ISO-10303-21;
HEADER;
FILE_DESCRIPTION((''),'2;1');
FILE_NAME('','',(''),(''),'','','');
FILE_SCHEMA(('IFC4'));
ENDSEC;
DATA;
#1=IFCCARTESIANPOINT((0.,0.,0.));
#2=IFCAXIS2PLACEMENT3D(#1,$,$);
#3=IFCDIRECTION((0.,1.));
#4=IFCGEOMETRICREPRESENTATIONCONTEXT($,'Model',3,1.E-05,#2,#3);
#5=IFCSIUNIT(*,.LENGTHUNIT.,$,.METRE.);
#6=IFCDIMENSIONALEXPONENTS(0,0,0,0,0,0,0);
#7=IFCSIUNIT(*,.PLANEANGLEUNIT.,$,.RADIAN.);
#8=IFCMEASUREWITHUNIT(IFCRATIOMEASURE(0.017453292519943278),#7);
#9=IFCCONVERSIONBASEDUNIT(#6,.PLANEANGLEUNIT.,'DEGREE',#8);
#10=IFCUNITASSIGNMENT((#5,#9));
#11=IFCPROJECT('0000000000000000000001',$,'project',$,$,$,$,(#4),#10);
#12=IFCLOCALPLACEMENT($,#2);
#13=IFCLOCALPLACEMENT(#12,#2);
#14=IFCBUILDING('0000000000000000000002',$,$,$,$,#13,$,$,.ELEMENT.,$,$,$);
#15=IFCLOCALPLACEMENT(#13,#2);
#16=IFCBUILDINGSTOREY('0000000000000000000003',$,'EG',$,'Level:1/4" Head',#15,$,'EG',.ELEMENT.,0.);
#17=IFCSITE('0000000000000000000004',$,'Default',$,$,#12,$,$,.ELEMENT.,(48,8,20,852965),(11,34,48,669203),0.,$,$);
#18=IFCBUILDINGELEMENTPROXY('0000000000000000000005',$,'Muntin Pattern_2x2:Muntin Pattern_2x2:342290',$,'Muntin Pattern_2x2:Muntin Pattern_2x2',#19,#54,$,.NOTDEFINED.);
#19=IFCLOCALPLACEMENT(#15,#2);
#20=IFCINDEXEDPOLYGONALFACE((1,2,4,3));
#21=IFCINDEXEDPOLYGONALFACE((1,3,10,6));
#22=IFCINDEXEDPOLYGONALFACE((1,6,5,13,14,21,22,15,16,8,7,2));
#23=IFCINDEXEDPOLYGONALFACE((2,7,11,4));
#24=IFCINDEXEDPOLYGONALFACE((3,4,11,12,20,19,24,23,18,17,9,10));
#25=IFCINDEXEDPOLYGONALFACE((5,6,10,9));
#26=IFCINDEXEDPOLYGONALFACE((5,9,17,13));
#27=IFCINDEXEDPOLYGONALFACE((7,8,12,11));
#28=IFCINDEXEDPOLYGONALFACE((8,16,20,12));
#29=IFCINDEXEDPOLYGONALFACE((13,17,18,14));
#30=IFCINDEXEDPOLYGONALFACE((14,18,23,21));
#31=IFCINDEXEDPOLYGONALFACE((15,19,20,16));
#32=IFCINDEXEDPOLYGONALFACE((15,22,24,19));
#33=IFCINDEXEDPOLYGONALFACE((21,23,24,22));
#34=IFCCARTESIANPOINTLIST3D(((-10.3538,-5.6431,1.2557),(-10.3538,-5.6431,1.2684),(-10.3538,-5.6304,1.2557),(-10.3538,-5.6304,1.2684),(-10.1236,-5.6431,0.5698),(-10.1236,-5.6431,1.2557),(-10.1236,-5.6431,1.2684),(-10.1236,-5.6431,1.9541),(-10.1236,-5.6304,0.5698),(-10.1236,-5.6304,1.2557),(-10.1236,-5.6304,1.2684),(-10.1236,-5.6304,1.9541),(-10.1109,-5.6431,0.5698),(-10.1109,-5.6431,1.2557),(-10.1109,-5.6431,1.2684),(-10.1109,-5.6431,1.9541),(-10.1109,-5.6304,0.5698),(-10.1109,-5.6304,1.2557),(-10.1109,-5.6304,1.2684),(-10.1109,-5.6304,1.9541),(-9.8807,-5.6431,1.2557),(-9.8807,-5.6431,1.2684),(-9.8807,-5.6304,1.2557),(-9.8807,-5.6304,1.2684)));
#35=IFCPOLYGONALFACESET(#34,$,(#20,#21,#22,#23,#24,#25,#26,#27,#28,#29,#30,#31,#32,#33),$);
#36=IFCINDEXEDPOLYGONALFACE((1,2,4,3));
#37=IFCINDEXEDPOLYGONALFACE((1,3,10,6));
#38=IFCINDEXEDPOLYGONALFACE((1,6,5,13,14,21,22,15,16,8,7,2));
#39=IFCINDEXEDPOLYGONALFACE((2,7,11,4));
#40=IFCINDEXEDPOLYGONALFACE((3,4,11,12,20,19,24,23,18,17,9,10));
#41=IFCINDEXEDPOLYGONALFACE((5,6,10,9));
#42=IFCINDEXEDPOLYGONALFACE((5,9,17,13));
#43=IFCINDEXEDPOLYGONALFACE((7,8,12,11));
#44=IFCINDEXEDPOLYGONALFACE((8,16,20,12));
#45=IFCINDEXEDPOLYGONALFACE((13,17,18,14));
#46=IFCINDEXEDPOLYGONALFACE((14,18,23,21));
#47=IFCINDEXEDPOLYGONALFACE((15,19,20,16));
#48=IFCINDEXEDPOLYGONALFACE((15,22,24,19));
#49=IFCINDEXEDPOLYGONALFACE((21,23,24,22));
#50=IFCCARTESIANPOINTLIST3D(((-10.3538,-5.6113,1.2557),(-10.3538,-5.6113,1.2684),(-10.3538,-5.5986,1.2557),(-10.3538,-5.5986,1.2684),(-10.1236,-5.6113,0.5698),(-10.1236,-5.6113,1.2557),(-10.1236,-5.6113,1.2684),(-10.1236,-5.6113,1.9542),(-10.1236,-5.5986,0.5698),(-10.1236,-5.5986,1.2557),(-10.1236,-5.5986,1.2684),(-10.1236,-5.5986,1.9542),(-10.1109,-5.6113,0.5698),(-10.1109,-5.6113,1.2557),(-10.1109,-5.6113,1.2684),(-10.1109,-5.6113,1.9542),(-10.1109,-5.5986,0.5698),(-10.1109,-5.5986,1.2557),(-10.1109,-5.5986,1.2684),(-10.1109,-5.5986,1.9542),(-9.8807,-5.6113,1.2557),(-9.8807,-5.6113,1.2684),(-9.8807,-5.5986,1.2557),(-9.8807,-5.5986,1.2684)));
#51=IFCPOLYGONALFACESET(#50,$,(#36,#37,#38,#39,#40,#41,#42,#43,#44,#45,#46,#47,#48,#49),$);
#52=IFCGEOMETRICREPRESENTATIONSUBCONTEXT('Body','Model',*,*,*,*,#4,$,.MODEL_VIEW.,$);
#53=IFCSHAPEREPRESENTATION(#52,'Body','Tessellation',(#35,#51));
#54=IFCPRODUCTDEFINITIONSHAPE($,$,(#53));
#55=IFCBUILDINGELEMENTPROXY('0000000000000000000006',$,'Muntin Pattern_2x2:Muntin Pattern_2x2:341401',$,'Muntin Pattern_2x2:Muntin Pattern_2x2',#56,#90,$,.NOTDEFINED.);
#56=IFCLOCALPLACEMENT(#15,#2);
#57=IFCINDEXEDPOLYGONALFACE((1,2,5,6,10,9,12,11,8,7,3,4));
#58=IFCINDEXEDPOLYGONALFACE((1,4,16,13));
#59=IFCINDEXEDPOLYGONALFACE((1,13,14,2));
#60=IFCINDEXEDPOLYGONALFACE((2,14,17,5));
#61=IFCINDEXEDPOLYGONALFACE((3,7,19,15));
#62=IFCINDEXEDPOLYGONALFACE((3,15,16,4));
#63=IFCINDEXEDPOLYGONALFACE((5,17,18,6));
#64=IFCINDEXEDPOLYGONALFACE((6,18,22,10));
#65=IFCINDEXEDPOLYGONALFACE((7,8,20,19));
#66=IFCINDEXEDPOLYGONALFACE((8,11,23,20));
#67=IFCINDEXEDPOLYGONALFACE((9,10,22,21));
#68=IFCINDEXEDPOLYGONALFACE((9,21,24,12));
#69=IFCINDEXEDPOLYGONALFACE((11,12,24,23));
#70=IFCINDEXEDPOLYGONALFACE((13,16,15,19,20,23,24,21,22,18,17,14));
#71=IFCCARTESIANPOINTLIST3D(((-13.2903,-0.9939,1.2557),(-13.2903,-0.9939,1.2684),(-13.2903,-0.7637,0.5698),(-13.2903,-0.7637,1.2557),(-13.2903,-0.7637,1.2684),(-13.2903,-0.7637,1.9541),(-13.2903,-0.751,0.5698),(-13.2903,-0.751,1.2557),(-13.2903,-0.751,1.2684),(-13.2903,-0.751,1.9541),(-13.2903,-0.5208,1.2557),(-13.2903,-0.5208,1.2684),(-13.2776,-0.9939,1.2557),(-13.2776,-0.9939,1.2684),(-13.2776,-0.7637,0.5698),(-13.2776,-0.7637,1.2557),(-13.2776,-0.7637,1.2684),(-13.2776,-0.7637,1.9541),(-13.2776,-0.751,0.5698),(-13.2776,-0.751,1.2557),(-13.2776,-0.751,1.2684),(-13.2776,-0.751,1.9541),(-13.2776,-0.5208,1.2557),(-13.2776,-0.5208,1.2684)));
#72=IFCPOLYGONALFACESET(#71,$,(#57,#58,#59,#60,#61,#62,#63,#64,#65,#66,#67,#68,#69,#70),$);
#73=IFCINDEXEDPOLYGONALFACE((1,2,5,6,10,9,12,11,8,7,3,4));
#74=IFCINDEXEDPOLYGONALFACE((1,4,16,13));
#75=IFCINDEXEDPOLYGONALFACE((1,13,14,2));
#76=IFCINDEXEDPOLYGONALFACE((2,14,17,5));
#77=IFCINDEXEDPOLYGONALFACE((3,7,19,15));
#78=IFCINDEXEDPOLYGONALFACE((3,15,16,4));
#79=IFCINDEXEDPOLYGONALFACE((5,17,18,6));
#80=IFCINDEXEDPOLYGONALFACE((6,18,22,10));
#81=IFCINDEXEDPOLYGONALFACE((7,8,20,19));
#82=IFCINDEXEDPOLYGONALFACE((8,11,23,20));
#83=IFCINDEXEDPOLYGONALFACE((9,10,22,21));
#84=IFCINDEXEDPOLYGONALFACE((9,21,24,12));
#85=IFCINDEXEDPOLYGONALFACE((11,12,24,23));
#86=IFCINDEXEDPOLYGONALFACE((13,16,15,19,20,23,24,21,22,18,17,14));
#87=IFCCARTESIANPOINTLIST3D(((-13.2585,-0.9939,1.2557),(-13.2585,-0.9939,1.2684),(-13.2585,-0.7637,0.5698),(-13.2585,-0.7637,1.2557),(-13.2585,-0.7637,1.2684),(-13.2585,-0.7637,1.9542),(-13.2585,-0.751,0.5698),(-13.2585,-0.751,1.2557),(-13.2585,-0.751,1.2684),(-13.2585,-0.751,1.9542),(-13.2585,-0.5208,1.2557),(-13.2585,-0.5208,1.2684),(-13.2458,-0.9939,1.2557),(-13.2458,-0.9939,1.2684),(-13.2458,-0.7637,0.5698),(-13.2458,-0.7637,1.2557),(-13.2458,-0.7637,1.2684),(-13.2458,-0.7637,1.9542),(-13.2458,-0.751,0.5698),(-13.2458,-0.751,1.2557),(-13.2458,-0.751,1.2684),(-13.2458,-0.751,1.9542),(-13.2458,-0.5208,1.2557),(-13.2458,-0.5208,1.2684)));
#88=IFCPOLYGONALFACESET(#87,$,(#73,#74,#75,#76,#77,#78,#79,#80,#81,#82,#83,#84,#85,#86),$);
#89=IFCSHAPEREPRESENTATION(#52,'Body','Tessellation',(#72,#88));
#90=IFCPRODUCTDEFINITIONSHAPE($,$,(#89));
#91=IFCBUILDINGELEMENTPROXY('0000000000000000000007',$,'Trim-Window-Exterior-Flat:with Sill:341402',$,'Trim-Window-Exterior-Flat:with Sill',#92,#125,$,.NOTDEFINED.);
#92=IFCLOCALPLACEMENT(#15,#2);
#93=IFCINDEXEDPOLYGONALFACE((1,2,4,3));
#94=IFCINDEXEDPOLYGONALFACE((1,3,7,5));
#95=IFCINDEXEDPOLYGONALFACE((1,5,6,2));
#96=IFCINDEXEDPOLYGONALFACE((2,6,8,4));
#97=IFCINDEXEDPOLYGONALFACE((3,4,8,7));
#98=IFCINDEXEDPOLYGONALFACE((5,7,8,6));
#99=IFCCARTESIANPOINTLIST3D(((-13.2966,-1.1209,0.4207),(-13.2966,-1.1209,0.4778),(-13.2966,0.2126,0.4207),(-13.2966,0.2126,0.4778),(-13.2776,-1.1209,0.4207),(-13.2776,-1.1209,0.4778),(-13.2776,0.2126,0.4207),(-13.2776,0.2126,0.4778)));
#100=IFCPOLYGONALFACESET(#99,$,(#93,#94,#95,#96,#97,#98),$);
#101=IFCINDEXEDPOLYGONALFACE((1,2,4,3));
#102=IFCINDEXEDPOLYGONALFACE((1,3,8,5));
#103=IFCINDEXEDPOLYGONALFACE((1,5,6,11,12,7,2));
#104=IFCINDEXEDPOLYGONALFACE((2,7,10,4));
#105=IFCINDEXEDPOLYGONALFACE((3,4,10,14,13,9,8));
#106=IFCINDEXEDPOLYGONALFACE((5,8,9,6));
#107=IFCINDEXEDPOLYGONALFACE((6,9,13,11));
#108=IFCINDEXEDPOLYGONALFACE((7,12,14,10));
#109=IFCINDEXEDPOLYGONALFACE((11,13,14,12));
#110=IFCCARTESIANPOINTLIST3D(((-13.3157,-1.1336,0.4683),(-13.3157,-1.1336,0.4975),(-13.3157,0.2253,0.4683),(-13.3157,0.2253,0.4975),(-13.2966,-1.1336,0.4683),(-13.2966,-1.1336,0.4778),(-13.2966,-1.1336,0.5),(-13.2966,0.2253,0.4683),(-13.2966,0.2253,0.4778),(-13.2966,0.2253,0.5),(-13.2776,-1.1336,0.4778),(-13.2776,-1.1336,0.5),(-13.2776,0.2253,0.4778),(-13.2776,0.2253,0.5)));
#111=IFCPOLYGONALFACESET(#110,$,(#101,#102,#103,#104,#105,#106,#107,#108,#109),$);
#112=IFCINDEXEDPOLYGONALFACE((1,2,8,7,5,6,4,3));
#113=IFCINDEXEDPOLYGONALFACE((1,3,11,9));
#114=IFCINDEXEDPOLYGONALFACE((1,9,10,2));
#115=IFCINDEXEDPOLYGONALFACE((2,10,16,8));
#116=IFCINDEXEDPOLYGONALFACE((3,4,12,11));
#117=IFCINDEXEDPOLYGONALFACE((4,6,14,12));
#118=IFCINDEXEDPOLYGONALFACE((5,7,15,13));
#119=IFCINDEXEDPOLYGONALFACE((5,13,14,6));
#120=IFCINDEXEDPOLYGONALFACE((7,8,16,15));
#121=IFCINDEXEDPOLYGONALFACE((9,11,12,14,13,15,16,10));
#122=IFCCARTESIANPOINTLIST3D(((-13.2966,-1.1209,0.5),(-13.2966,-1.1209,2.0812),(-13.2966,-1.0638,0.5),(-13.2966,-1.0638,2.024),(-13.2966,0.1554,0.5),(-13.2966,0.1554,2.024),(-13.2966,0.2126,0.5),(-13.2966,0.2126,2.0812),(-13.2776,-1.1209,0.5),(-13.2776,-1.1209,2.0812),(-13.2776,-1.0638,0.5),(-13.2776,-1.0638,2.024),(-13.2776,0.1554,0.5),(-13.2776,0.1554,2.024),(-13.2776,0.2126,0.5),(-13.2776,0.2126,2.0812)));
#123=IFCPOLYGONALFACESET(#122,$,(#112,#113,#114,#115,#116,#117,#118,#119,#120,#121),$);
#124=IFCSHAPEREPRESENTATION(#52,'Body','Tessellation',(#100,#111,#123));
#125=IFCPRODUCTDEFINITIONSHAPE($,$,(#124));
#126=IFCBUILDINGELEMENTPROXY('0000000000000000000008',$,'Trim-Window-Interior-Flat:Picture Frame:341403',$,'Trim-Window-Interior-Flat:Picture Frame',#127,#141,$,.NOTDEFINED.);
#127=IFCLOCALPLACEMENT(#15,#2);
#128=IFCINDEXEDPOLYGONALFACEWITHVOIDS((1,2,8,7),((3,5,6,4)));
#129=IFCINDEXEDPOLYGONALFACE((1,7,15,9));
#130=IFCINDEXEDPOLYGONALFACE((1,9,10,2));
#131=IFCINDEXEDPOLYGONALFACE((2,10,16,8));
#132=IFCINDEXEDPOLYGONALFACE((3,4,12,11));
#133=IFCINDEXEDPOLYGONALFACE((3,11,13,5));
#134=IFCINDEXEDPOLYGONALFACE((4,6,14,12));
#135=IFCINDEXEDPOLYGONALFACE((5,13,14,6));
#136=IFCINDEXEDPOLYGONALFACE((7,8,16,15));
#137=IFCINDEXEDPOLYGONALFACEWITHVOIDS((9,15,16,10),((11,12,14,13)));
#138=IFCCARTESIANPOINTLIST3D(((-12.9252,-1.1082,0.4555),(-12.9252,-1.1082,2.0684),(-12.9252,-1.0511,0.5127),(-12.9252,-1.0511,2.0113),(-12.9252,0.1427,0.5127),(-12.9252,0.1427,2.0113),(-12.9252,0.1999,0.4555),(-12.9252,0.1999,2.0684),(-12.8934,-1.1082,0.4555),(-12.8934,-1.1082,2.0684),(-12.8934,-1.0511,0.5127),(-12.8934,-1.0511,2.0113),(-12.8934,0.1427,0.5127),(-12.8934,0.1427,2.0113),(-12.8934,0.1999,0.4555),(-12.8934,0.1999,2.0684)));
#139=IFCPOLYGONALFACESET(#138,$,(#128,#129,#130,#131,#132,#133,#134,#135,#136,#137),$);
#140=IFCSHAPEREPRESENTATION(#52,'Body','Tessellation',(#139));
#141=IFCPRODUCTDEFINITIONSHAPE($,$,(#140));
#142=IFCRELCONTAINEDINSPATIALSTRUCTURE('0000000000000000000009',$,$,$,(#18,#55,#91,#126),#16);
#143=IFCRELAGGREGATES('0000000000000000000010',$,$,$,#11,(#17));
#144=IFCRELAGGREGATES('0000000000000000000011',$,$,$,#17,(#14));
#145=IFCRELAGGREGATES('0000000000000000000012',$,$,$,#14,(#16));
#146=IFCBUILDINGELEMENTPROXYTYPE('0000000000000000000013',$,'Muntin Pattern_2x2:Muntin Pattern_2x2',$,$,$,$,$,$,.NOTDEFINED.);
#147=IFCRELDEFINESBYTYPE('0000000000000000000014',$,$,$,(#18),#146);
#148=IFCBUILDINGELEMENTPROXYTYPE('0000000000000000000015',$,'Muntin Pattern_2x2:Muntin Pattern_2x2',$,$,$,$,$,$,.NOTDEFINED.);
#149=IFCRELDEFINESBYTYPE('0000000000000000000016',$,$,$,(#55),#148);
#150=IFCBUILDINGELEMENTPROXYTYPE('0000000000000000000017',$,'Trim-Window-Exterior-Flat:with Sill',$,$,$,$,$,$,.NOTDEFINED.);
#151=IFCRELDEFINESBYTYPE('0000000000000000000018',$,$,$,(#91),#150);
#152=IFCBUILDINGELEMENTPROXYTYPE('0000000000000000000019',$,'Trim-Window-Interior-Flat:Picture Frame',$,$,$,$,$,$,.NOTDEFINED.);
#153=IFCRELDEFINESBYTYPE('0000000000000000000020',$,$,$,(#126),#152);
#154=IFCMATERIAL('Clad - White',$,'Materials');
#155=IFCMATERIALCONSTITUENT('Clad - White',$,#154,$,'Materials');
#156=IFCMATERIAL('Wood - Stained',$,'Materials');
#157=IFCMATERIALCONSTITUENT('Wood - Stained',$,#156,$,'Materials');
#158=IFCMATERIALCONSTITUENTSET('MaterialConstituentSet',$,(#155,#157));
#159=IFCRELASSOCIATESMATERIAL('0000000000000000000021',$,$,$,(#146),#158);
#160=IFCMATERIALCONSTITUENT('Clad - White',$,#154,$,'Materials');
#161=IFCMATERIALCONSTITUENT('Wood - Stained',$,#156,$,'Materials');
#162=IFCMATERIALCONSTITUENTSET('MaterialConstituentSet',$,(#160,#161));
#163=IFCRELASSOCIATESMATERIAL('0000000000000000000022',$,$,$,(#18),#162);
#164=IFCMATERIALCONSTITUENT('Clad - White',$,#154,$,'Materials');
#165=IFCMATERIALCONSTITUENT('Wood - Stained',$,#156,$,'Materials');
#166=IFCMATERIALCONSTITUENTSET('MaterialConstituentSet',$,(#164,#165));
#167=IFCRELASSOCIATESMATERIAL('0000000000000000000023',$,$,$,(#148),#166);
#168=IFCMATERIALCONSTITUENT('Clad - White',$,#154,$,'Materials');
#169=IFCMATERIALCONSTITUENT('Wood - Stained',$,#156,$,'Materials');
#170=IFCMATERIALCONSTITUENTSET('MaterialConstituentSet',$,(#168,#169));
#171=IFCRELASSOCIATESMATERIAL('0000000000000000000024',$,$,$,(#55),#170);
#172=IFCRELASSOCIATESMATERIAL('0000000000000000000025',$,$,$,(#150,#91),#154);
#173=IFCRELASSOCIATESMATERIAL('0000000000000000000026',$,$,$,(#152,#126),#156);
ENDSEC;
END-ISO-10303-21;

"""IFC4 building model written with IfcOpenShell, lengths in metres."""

from ifc_helpers import new_model, entity, si_unit, converted_unit, direction, frame, origin, place, context, subcontext, project, spatial, indexed_curve, outline, extrude, source, transform, mapped, material, constituent, constituent_set, type_object, type_shapes, element, save


model = new_model("IFC4")

# Units and contexts
model_context = context("Model", 3, precision=1e-05, world=origin(), true_north=direction((0.0, 1.0)))
body_context = subcontext(model_context, "Body", "Model", "MODEL_VIEW")
ifc_project = project(units=[si_unit("LENGTHUNIT", "METRE"), converted_unit("PLANEANGLEUNIT", "DEGREE", entity("IfcRatioMeasure", 0.017453292519943278), si_unit("PLANEANGLEUNIT", "RADIAN"), dimensions=[0, 0, 0, 0, 0, 0, 0])], contexts=[model_context])

# Site, building, storey
site_placement = place(None, origin())
site = spatial("IfcSite", under=ifc_project, at=site_placement, Name="Default", CompositionType="ELEMENT", RefLatitude=(48, 8, 20, 852965), RefLongitude=(11, 34, 48, 669203), RefElevation=0.0)
building_placement = place(site_placement, origin())
building = spatial("IfcBuilding", under=site, at=building_placement, CompositionType="ELEMENT")
storey_placement = place(building_placement, origin())
storey = spatial("IfcBuildingStorey", under=building, at=storey_placement, Name="EG", ObjectType="Level:1/4\" Head", LongName="EG", CompositionType="ELEMENT", Elevation=0.0)

# Building element proxies
ifc_material_1 = material(Name="Clad - White", Category="Materials")
ifc_material_2 = material(Name="Wood - Stained", Category="Materials")
ifc_constituent_1 = constituent(ifc_material_1, Name="Clad - White", Category="Materials")
ifc_constituent_2 = constituent(ifc_material_2, Name="Wood - Stained", Category="Materials")
ifc_constituent_set_1 = constituent_set(constituents=[ifc_constituent_1, ifc_constituent_2], Name="MaterialConstituentSet")
building_element_proxy_type_1 = type_object("IfcBuildingElementProxyType", Name="Muntin Pattern_2x2:Muntin Pattern_2x2", PredefinedType="NOTDEFINED", material=ifc_constituent_set_1)
shared_shape_1 = source(origin(), body_context, "Body", "SweptSolid", [
    extrude(outline(indexed_curve([(0.0064, -0.0064), (0.6921, -0.0064), (0.6921, 0.0063), (0.0064, 0.0063), (0.0064, 0.2365), (-0.0063, 0.2365), (-0.0063, 0.0063), (-0.6922, 0.0063), (-0.6922, -0.0064), (-0.0063, -0.0064), (-0.0063, -0.2365), (0.0064, -0.2365), (0.0064, -0.0064)], self_intersect=False)), frame((0.0, -0.0222, 0.6921), z_axis=(0.0, 1.0, 0.0), x_axis=(0.0, 0.0, 1.0)), (0.0, 0.0, 1.0), 0.0127),
    extrude(outline(indexed_curve([(0.0064, -0.0064), (0.6922, -0.0064), (0.6922, 0.0063), (0.0064, 0.0063), (0.0064, 0.2365), (-0.0063, 0.2365), (-0.0063, 0.0063), (-0.6922, 0.0063), (-0.6922, -0.0064), (-0.0063, -0.0064), (-0.0063, -0.2365), (0.0064, -0.2365), (0.0064, -0.0064)], self_intersect=False)), frame((0.0, 0.0095, 0.6922), z_axis=(0.0, 1.0, 0.0), x_axis=(0.0, 0.0, 1.0)), (0.0, 0.0, 1.0), 0.0127),
])
type_shapes(building_element_proxy_type_1, [shared_shape_1])
ifc_constituent_3 = constituent(ifc_material_1, Name="Clad - White", Category="Materials")
ifc_constituent_4 = constituent(ifc_material_2, Name="Wood - Stained", Category="Materials")
ifc_constituent_set_2 = constituent_set(constituents=[ifc_constituent_3, ifc_constituent_4], Name="MaterialConstituentSet")
proxy_1_placement = place(storey_placement, frame((-10.1173, -5.6209, 0.5699)))
element("IfcBuildingElementProxy", 1, at=proxy_1_placement, inside=storey, type_object=building_element_proxy_type_1, material=ifc_constituent_set_2, Name="Muntin Pattern_2x2:Muntin Pattern_2x2:342290", ObjectType="Muntin Pattern_2x2:Muntin Pattern_2x2", PredefinedType="NOTDEFINED", context=body_context, shape_type="MappedRepresentation", body=[
    mapped(shared_shape_1, transform((0.0, 0.0, 0.0), scale=1.0)),
])
ifc_constituent_5 = constituent(ifc_material_1, Name="Clad - White", Category="Materials")
ifc_constituent_6 = constituent(ifc_material_2, Name="Wood - Stained", Category="Materials")
ifc_constituent_set_3 = constituent_set(constituents=[ifc_constituent_5, ifc_constituent_6], Name="MaterialConstituentSet")
ifc_constituent_7 = constituent(ifc_material_1, Name="Clad - White", Category="Materials")
ifc_constituent_8 = constituent(ifc_material_2, Name="Wood - Stained", Category="Materials")
ifc_constituent_set_4 = constituent_set(constituents=[ifc_constituent_7, ifc_constituent_8], Name="MaterialConstituentSet")
building_element_proxy_type_2 = type_object("IfcBuildingElementProxyType", Name="Muntin Pattern_2x2:Muntin Pattern_2x2", PredefinedType="NOTDEFINED", material=ifc_constituent_set_4)
shared_shape_2 = source(origin(), body_context, "Body", "SweptSolid", [
    extrude(outline(indexed_curve([(0.0064, -0.0064), (0.6921, -0.0064), (0.6921, 0.0063), (0.0064, 0.0063), (0.0064, 0.2365), (-0.0063, 0.2365), (-0.0063, 0.0063), (-0.6922, 0.0063), (-0.6922, -0.0064), (-0.0063, -0.0064), (-0.0063, -0.2365), (0.0064, -0.2365), (0.0064, -0.0064)], self_intersect=False)), frame((0.0, 0.0095, 0.6921), z_axis=(0.0, 1.0, 0.0), x_axis=(0.0, 0.0, 1.0)), (0.0, 0.0, 1.0), 0.0127),
    extrude(outline(indexed_curve([(0.0064, -0.0064), (0.6922, -0.0064), (0.6922, 0.0063), (0.0064, 0.0063), (0.0064, 0.2365), (-0.0063, 0.2365), (-0.0063, 0.0063), (-0.6922, 0.0063), (-0.6922, -0.0064), (-0.0063, -0.0064), (-0.0063, -0.2365), (0.0064, -0.2365), (0.0064, -0.0064)], self_intersect=False)), frame((0.0, -0.0222, 0.6922), z_axis=(0.0, 1.0, 0.0), x_axis=(0.0, 0.0, 1.0)), (0.0, 0.0, 1.0), 0.0127),
])
type_shapes(building_element_proxy_type_2, [shared_shape_2])
proxy_2_placement = place(storey_placement, frame((-13.2681, -0.7574, 0.5699), z_axis=(0.0, 0.0, 1.0), x_axis=(0.0, 1.0, 0.0)))
element("IfcBuildingElementProxy", 2, at=proxy_2_placement, inside=storey, type_object=building_element_proxy_type_2, material=ifc_constituent_set_3, Name="Muntin Pattern_2x2:Muntin Pattern_2x2:341401", ObjectType="Muntin Pattern_2x2:Muntin Pattern_2x2", PredefinedType="NOTDEFINED", context=body_context, shape_type="MappedRepresentation", body=[
    mapped(shared_shape_2, transform((0.0, 0.0, 0.0), scale=1.0)),
])
building_element_proxy_type_3 = type_object("IfcBuildingElementProxyType", Name="Trim-Window-Exterior-Flat:with Sill", PredefinedType="NOTDEFINED", material=ifc_material_1)
shared_shape_3 = source(origin(), body_context, "Body", "SweptSolid", [
    extrude(outline(indexed_curve([(-0.0286, -0.6667), (0.0286, -0.6667), (0.0286, 0.6667), (-0.0286, 0.6667), (-0.0286, -0.6667)], self_intersect=False)), frame((0.0, 1.5748, 0.0), z_axis=(0.0, 0.0, 1.0), x_axis=(0.0, 1.0, 0.0)), (0.0, 0.0, 1.0), 0.019),
    extrude(outline(indexed_curve([(-0.016, -0.019), (0.0133, -0.019), (0.0158, 0.0), (0.0158, 0.019), (-0.0064, 0.019), (-0.0064, 0.0), (-0.016, 0.0), (-0.016, -0.019)], self_intersect=False)), frame((-0.6794, 1.5398, 0.019), z_axis=(1.0, 0.0, 0.0), x_axis=(0.0, -1.0, 0.0)), (0.0, 0.0, 1.0), 1.3589),
    extrude(outline(indexed_curve([(-0.6667, -0.8049), (0.6667, -0.8049), (0.6667, 0.7763), (0.6096, 0.7763), (0.6096, -0.7477), (-0.6096, -0.7477), (-0.6096, 0.7763), (-0.6667, 0.7763), (-0.6667, -0.8049)], self_intersect=False)), frame((0.0, 0.7477, 0.0)), (0.0, 0.0, 1.0), 0.019),
])
type_shapes(building_element_proxy_type_3, [shared_shape_3])
proxy_3_placement = place(storey_placement, frame((-13.2776, -0.4542, 2.024), z_axis=(-1.0, 0.0, 0.0), x_axis=(0.0, 1.0, 0.0)))
element("IfcBuildingElementProxy", 3, at=proxy_3_placement, inside=storey, type_object=building_element_proxy_type_3, material=ifc_material_1, Name="Trim-Window-Exterior-Flat:with Sill:341402", ObjectType="Trim-Window-Exterior-Flat:with Sill", PredefinedType="NOTDEFINED", context=body_context, shape_type="MappedRepresentation", body=[
    mapped(shared_shape_3, transform((0.0, 0.0, 0.0), scale=1.0)),
])
building_element_proxy_type_4 = type_object("IfcBuildingElementProxyType", Name="Trim-Window-Interior-Flat:Picture Frame", PredefinedType="NOTDEFINED", material=ifc_material_2)
shared_shape_4 = source(origin(), body_context, "Body", "SweptSolid", [
    extrude(outline(indexed_curve([(-0.8064, -0.654), (0.8064, -0.654), (0.8064, 0.654), (-0.8064, 0.654), (-0.8064, -0.654)], self_intersect=False), holes=[indexed_curve([(-0.7493, -0.5969), (-0.7493, 0.5969), (0.7493, 0.5969), (0.7493, -0.5969), (-0.7493, -0.5969)], self_intersect=False)]), frame((0.0, 0.762, 0.0), z_axis=(0.0, 0.0, 1.0), x_axis=(0.0, 1.0, 0.0)), (0.0, 0.0, 1.0), 0.0317),
])
type_shapes(building_element_proxy_type_4, [shared_shape_4])
proxy_4_placement = place(storey_placement, frame((-12.9252, -0.4542, 2.024), z_axis=(1.0, 0.0, 0.0), x_axis=(0.0, -1.0, 0.0)))
element("IfcBuildingElementProxy", 4, at=proxy_4_placement, inside=storey, type_object=building_element_proxy_type_4, material=ifc_material_2, Name="Trim-Window-Interior-Flat:Picture Frame:341403", ObjectType="Trim-Window-Interior-Flat:Picture Frame", PredefinedType="NOTDEFINED", context=body_context, shape_type="MappedRepresentation", body=[
    mapped(shared_shape_4, transform((0.0, 0.0, 0.0), scale=1.0)),
])

save(model, "model.ifc")
